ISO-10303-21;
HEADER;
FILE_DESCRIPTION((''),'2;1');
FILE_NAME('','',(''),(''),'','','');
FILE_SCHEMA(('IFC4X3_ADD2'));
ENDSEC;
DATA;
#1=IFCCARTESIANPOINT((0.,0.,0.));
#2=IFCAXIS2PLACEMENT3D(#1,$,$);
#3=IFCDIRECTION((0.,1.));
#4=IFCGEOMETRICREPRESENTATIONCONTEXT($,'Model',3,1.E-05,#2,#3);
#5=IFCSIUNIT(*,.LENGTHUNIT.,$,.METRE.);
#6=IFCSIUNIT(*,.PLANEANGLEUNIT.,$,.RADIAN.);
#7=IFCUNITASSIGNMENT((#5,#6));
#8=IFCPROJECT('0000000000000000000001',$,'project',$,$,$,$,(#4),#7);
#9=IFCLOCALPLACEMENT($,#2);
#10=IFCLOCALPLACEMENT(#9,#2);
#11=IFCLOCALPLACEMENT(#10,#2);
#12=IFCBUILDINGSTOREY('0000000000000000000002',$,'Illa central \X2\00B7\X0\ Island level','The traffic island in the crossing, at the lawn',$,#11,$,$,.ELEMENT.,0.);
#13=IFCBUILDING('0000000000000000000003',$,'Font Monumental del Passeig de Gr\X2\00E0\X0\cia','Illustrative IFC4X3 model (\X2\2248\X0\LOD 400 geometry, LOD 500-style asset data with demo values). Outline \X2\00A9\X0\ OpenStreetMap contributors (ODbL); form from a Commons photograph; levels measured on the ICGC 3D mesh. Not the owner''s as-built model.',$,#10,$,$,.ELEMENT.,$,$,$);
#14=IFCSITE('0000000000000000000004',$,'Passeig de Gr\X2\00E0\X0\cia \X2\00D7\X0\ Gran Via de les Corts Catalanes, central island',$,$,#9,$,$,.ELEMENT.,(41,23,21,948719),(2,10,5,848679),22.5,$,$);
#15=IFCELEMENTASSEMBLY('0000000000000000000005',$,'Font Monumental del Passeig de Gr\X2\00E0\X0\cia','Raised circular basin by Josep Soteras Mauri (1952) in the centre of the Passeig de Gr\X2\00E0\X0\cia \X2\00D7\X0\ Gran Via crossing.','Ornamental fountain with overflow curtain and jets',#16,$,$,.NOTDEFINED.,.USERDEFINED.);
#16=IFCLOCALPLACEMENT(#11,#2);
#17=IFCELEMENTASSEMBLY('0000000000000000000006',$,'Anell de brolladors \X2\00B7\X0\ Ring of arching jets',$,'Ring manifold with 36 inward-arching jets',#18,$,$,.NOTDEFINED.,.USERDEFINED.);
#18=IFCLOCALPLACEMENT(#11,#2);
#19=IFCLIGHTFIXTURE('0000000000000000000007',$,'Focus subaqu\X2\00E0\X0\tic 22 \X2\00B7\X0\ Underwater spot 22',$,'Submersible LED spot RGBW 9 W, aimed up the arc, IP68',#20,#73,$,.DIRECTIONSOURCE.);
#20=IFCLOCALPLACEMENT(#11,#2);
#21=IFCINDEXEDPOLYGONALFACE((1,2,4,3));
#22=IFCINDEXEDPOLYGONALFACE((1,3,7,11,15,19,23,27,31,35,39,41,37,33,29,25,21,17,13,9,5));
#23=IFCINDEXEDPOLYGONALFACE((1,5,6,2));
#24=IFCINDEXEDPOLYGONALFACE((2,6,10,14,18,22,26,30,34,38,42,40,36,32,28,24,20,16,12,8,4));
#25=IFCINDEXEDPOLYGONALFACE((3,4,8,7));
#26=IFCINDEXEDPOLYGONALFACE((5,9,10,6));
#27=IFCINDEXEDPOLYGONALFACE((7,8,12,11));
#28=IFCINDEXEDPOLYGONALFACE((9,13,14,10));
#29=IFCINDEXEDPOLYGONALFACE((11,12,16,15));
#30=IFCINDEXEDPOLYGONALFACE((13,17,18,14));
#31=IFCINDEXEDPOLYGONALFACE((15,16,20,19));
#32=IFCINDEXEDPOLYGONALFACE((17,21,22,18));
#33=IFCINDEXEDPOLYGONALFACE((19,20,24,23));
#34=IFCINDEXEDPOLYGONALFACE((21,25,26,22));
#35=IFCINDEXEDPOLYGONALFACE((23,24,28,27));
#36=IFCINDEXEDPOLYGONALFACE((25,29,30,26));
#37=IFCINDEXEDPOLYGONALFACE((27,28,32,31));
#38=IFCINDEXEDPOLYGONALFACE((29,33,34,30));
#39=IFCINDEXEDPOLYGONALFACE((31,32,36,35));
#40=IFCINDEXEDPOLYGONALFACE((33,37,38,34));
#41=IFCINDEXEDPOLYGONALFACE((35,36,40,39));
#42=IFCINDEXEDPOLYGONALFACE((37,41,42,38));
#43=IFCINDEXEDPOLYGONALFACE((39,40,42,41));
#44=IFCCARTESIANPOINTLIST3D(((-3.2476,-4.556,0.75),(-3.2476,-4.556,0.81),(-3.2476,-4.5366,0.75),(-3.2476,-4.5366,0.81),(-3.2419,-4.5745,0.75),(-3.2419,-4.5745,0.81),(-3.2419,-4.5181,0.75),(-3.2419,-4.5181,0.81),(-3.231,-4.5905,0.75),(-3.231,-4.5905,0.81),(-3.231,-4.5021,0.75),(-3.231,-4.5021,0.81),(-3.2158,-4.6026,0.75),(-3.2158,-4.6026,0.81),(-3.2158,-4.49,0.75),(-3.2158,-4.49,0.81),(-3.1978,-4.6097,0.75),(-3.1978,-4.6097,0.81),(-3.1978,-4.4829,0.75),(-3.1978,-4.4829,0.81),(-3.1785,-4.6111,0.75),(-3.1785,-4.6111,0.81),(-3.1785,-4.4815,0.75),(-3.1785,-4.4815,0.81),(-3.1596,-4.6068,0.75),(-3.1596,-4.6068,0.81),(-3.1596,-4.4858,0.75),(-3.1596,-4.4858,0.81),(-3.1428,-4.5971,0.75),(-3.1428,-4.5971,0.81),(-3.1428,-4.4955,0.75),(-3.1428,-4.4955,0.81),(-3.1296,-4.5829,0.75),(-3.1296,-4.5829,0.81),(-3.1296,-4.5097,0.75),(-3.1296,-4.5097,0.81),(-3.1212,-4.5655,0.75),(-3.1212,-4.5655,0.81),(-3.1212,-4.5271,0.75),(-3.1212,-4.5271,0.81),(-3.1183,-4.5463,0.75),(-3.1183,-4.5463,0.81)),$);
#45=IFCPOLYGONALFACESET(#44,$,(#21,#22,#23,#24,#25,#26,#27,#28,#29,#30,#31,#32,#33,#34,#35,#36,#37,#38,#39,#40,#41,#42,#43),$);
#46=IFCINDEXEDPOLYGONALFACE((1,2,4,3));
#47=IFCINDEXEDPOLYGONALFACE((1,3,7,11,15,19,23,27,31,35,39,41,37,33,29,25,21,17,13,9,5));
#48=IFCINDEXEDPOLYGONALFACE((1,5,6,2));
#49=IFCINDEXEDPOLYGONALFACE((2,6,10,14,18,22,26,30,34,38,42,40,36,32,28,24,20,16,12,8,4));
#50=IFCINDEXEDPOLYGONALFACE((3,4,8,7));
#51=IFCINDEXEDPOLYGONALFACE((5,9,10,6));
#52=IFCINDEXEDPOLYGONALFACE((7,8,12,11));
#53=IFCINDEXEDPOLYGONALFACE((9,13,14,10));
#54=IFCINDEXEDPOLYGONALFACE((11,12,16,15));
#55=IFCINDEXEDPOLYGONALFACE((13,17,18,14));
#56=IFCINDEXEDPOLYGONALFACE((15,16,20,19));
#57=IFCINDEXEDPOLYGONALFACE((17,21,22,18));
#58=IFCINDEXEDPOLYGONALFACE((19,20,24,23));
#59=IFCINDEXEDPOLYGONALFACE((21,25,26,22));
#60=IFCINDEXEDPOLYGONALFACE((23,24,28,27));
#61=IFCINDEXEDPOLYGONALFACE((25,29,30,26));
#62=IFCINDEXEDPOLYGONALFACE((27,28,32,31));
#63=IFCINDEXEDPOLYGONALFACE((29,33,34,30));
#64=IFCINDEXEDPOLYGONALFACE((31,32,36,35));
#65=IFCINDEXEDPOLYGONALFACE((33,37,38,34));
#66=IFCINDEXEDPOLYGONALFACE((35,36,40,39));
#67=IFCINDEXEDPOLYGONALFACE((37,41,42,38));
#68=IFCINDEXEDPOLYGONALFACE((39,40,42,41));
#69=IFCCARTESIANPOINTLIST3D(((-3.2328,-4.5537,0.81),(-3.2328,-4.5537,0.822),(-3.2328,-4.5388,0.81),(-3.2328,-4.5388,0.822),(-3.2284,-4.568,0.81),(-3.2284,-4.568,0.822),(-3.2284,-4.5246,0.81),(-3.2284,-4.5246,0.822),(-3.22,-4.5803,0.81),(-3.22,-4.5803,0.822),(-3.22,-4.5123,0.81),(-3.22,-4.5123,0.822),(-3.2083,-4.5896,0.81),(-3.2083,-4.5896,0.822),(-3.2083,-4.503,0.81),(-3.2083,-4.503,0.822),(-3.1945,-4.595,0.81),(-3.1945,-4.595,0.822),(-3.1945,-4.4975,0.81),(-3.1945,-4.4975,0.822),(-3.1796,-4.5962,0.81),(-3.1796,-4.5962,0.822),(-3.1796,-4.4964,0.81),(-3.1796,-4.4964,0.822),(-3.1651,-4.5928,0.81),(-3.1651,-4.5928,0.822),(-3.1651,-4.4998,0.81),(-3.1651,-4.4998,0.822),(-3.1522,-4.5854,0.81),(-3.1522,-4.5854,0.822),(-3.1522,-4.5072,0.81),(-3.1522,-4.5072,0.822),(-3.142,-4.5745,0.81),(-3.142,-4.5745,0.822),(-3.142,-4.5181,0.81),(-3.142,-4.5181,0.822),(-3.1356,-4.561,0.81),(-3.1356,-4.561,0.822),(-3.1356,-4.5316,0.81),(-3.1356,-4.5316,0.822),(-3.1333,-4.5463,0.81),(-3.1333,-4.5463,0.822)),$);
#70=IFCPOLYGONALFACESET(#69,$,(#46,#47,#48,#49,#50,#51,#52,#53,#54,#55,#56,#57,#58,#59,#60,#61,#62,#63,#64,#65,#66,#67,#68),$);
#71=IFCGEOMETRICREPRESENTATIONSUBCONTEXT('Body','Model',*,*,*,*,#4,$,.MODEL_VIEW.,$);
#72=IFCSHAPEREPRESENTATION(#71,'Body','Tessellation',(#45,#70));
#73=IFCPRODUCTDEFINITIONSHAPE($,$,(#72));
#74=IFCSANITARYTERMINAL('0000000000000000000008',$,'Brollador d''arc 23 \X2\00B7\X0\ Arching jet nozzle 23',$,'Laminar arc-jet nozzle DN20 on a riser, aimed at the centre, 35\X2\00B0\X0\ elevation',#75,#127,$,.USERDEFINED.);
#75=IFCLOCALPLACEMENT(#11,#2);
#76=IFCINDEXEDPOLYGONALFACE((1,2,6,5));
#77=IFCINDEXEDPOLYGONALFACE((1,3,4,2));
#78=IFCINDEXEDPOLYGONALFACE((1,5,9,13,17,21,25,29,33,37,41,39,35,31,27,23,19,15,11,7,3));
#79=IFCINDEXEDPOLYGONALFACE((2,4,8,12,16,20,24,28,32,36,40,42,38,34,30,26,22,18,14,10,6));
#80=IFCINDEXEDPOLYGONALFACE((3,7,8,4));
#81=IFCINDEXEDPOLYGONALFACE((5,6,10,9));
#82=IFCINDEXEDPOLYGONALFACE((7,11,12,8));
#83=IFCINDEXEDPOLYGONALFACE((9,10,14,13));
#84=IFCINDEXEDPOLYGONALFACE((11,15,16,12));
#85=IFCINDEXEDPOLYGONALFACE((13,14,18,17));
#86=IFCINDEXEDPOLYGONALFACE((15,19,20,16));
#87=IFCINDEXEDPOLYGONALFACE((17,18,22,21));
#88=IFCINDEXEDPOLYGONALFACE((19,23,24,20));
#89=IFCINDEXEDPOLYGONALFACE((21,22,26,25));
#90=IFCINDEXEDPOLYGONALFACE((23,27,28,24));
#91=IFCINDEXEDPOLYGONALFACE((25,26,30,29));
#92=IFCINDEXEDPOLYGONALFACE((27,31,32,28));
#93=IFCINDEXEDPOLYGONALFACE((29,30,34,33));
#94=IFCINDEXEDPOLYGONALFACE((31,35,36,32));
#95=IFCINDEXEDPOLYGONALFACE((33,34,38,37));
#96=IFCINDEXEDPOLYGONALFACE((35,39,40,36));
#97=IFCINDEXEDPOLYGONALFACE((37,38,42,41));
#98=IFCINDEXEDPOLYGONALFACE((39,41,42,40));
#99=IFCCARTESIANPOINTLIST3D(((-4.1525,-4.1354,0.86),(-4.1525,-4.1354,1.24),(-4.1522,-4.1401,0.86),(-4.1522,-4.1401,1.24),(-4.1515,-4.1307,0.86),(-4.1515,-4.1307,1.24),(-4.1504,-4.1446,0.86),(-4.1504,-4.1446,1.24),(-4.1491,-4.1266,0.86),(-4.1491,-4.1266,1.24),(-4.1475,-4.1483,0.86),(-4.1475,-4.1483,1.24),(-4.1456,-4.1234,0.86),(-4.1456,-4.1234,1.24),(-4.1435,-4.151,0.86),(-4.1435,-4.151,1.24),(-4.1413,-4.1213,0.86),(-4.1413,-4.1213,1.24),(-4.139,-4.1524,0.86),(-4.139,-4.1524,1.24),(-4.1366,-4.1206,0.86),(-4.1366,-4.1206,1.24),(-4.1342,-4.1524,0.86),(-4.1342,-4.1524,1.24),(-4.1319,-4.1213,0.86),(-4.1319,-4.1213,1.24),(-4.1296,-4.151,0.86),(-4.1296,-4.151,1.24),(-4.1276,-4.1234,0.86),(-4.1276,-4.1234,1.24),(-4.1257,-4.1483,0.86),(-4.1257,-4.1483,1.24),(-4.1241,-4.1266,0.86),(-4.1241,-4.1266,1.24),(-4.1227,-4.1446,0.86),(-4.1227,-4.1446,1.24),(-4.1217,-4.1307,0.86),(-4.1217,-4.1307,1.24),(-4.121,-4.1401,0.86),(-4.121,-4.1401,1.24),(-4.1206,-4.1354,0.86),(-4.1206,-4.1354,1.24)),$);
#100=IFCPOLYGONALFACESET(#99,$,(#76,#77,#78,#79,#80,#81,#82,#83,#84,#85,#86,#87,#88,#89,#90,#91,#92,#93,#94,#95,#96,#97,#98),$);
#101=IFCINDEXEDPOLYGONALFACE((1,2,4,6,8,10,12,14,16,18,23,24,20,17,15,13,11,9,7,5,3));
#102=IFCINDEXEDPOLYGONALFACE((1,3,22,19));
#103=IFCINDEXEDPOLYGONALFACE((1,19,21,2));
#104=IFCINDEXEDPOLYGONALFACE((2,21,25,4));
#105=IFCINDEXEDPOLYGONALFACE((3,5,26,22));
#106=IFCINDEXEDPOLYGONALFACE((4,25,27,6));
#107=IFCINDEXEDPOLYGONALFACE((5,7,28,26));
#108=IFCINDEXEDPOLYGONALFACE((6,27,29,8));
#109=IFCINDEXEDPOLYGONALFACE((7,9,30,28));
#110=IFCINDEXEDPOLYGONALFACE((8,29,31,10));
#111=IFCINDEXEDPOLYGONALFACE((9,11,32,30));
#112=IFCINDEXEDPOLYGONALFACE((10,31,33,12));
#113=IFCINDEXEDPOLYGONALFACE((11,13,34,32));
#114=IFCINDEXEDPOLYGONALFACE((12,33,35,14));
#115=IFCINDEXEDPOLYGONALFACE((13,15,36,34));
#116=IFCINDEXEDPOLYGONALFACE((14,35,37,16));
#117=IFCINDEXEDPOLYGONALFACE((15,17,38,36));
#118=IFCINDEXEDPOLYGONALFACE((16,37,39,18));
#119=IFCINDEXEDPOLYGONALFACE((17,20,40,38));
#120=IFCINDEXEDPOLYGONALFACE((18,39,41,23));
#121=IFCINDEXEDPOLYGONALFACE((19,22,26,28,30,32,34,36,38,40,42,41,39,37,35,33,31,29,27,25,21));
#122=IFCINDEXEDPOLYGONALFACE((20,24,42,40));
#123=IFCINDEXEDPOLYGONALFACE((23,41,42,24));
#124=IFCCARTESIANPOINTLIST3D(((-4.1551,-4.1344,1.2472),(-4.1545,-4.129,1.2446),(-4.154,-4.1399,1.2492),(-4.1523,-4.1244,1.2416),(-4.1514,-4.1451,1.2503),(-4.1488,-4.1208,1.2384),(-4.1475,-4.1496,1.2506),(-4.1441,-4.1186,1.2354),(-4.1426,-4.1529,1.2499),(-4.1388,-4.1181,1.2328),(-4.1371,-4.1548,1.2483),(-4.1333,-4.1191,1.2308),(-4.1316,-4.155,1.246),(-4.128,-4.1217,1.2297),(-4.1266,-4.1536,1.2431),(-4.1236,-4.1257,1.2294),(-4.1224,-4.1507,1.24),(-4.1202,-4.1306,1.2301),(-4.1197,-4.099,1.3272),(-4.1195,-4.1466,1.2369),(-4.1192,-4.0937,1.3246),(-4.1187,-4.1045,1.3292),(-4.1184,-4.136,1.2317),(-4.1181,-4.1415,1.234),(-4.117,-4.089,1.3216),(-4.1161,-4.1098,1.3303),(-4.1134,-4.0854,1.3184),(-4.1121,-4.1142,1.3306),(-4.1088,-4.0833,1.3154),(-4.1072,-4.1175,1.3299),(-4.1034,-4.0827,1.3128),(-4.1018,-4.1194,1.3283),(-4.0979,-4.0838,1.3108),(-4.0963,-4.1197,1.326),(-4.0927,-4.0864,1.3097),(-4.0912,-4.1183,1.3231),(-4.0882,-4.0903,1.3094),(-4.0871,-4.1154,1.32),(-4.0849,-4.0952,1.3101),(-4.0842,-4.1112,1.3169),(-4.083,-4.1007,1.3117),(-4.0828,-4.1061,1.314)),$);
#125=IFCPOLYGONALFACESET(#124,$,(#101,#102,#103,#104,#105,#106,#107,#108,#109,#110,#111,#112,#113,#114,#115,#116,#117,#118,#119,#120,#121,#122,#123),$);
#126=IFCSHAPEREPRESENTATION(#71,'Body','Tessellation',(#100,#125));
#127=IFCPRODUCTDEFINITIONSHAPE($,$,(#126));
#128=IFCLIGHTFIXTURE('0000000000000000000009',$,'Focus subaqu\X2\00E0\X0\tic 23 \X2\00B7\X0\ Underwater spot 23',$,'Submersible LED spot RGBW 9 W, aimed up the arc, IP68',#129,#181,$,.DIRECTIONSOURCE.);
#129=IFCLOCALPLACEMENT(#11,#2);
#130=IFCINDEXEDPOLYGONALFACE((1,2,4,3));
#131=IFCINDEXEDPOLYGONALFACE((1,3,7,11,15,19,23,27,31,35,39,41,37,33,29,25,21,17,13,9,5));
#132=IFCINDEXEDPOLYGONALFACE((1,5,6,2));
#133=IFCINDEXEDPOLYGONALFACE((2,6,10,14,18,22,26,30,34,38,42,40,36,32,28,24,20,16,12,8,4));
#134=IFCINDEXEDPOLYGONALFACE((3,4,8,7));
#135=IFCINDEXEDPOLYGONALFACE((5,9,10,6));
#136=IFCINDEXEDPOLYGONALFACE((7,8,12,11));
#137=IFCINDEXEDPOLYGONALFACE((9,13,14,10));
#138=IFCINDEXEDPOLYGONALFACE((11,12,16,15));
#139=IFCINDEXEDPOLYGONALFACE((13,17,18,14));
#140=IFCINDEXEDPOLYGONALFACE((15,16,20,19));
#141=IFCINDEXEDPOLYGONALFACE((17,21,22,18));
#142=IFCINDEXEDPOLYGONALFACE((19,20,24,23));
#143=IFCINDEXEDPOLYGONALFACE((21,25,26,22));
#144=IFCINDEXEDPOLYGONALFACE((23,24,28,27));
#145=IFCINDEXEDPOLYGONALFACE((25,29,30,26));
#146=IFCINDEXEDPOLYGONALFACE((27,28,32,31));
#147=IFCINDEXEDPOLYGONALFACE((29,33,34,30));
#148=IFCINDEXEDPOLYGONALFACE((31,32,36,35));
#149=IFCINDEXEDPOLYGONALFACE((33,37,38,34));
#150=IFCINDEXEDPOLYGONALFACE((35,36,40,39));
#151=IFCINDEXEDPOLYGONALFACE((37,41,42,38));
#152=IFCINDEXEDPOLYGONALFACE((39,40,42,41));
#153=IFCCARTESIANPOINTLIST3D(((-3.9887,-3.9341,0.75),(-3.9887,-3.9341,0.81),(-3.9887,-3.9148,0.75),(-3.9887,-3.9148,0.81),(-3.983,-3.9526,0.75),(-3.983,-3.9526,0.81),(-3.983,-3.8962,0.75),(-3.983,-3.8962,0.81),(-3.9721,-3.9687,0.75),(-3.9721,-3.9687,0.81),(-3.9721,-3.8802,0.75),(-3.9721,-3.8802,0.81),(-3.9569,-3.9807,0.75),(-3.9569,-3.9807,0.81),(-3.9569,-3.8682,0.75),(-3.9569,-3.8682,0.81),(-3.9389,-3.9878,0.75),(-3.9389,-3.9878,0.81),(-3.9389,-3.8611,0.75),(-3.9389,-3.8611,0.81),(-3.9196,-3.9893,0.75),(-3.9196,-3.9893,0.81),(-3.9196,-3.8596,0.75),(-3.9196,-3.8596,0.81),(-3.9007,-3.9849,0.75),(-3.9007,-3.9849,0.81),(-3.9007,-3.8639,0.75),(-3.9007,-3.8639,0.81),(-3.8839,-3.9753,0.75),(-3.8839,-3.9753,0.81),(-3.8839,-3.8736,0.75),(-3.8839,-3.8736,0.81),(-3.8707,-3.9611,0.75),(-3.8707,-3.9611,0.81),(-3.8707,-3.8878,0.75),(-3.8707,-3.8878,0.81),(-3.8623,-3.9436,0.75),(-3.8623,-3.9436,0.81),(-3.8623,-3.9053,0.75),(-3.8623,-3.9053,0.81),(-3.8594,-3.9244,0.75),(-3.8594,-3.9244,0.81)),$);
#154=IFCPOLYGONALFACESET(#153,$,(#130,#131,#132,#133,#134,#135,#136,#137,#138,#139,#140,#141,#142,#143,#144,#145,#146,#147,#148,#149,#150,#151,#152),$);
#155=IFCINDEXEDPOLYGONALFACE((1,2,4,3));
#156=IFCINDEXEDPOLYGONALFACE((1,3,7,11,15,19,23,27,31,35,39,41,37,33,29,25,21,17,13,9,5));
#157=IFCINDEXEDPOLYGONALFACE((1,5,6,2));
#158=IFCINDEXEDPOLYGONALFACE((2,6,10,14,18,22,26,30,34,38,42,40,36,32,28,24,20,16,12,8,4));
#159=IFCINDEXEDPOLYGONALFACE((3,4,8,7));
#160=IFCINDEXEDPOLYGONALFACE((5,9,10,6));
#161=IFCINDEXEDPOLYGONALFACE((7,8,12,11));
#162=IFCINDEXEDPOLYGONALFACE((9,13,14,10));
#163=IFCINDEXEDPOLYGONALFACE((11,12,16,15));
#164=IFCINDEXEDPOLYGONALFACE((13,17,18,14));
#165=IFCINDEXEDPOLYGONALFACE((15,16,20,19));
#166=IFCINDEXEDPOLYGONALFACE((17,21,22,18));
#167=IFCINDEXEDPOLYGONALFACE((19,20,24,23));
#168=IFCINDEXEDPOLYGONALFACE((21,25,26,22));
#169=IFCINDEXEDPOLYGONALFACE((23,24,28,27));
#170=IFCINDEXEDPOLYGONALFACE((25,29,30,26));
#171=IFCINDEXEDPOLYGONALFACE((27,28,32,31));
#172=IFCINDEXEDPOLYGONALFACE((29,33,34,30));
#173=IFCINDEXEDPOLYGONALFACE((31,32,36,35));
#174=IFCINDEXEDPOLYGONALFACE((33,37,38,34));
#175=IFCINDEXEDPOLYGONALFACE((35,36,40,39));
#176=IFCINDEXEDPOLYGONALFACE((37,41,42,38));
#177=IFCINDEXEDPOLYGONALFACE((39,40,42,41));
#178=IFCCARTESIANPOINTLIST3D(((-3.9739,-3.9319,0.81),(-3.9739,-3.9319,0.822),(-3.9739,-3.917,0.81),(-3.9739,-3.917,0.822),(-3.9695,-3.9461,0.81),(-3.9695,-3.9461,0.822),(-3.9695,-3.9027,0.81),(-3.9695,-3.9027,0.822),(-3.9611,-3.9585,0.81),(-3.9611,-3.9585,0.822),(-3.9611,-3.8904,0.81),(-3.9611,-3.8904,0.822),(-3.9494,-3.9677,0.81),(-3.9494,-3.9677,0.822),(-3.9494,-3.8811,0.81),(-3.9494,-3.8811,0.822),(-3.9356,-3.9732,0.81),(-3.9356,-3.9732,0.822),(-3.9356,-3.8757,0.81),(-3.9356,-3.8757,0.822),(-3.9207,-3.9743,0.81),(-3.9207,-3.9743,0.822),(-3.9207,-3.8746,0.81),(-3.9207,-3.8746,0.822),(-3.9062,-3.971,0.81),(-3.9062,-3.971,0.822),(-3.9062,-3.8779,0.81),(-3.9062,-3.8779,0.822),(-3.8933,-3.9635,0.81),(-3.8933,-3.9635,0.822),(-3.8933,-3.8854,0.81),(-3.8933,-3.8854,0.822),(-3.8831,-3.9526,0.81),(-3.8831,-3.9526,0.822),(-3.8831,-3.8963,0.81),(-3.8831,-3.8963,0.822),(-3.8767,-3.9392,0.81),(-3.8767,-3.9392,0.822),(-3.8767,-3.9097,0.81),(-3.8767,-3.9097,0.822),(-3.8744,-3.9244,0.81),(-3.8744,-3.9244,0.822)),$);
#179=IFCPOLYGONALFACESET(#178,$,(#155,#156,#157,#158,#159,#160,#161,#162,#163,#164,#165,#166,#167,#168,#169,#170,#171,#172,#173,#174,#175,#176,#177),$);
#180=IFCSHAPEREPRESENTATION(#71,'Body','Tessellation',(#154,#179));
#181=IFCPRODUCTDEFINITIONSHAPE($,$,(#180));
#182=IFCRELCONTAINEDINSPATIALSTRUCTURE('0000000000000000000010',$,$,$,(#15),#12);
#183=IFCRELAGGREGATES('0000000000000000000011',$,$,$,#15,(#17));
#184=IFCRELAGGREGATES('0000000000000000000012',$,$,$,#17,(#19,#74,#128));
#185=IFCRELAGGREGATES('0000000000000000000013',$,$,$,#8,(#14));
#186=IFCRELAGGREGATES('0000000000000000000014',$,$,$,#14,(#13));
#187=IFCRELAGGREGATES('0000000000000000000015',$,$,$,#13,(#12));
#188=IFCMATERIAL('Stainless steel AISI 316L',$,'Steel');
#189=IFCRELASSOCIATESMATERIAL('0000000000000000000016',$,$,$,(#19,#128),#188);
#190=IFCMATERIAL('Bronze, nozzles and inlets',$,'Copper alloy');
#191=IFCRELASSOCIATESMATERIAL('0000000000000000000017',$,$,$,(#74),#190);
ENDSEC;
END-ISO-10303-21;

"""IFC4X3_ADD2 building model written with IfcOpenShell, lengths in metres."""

from ifc_helpers import new_model, si_unit, direction, frame, origin, origin_2d_with_axis, place, context, subcontext, project, spatial, circle, extrude, material, element, aggregate, save


model = new_model("IFC4X3_ADD2")

# Units and contexts
model_context = context("Model", 3, precision=1e-05, world=origin(), true_north=direction((0.0, 1.0)))
body_context = subcontext(model_context, "Body", "Model", "MODEL_VIEW")
ifc_project = project(units=[si_unit("LENGTHUNIT", "METRE"), si_unit("PLANEANGLEUNIT", "RADIAN")], contexts=[model_context])

# Site, building, storey
site_placement = place(None, origin())
site = spatial("IfcSite", under=ifc_project, at=site_placement, Name="Passeig de Gràcia × Gran Via de les Corts Catalanes, central island", CompositionType="ELEMENT", RefLatitude=(41, 23, 21, 948719), RefLongitude=(2, 10, 5, 848679), RefElevation=22.5)
building_placement = place(site_placement, origin())
building = spatial("IfcBuilding", under=site, at=building_placement, Name="Font Monumental del Passeig de Gràcia", Description="Illustrative IFC4X3 model (≈LOD 400 geometry, LOD 500-style asset data with demo values). Outline © OpenStreetMap contributors (ODbL); form from a Commons photograph; levels measured on the ICGC 3D mesh. Not the owner's as-built model.", CompositionType="ELEMENT")
storey_placement = place(building_placement, origin())
storey = spatial("IfcBuildingStorey", under=building, at=storey_placement, Name="Illa central · Island level", Description="The traffic island in the crossing, at the lawn", CompositionType="ELEMENT", Elevation=0.0)

# Element assemblies, light fixtures, sanitary terminal
assembly_1_placement = place(building_placement, origin())
assembly_1 = element("IfcElementAssembly", 1, at=assembly_1_placement, inside=storey, Name="Font Monumental del Passeig de Gràcia", Description="Raised circular basin by Josep Soteras Mauri (1952) in the centre of the Passeig de Gràcia × Gran Via crossing.", ObjectType="Ornamental fountain with overflow curtain and jets", AssemblyPlace="NOTDEFINED", PredefinedType="USERDEFINED")
assembly_2_placement = place(building_placement, origin())
assembly_2 = element("IfcElementAssembly", 2, at=assembly_2_placement, Name="Anell de brolladors · Ring of arching jets", ObjectType="Ring manifold with 36 inward-arching jets", AssemblyPlace="NOTDEFINED", PredefinedType="USERDEFINED")
aggregate(assembly_1, [assembly_2])
ifc_material_1 = material(Name="Stainless steel AISI 316L", Category="Steel")
ifc_material_2 = material(Name="Bronze, nozzles and inlets", Category="Copper alloy")
light_fixture_1_placement = place(building_placement, origin())
light_fixture_1 = element("IfcLightFixture", 3, at=light_fixture_1_placement, material=ifc_material_1, Name="Focus subaquàtic 22 · Underwater spot 22", ObjectType="Submersible LED spot RGBW 9 W, aimed up the arc, IP68", PredefinedType="DIRECTIONSOURCE", context=body_context, shape_type="SweptSolid", body=[
    extrude(circle(Radius=0.065, at=origin_2d_with_axis()), frame((-3.1833, -4.5463, 0.75)), (0.0, 0.0, 1.0), 0.06),
    extrude(circle(Radius=0.05, at=origin_2d_with_axis()), frame((-3.1833, -4.5463, 0.81)), (0.0, 0.0, 1.0), 0.012),
])
sanitary_terminal_1_placement = place(building_placement, origin())
sanitary_terminal_1 = element("IfcSanitaryTerminal", 4, at=sanitary_terminal_1_placement, material=ifc_material_2, Name="Brollador d'arc 23 · Arching jet nozzle 23", ObjectType="Laminar arc-jet nozzle DN20 on a riser, aimed at the centre, 35° elevation", PredefinedType="USERDEFINED", context=body_context, shape_type="SweptSolid", body=[
    extrude(circle(Radius=0.016, at=origin_2d_with_axis()), frame((-4.1366, -4.1366, 0.86), z_axis=(0.0, 0.0, 1.0), x_axis=(0.0, 1.0, 0.0)), (0.0, 0.0, 1.0), 0.38),
    extrude(circle(Radius=0.02, at=origin_2d_with_axis()), frame((-4.1366, -4.1366, 1.24), z_axis=(0.374766, 0.374766, 0.847998), x_axis=(0.707107, -0.707107, 0.0)), (0.0, 0.0, 1.0), 0.0943),
])
light_fixture_2_placement = place(building_placement, origin())
light_fixture_2 = element("IfcLightFixture", 5, at=light_fixture_2_placement, material=ifc_material_1, Name="Focus subaquàtic 23 · Underwater spot 23", ObjectType="Submersible LED spot RGBW 9 W, aimed up the arc, IP68", PredefinedType="DIRECTIONSOURCE", context=body_context, shape_type="SweptSolid", body=[
    extrude(circle(Radius=0.065, at=origin_2d_with_axis()), frame((-3.9244, -3.9244, 0.75)), (0.0, 0.0, 1.0), 0.06),
    extrude(circle(Radius=0.05, at=origin_2d_with_axis()), frame((-3.9244, -3.9244, 0.81)), (0.0, 0.0, 1.0), 0.012),
])
aggregate(assembly_2, [light_fixture_1, sanitary_terminal_1, light_fixture_2])

save(model, "model.ifc")
